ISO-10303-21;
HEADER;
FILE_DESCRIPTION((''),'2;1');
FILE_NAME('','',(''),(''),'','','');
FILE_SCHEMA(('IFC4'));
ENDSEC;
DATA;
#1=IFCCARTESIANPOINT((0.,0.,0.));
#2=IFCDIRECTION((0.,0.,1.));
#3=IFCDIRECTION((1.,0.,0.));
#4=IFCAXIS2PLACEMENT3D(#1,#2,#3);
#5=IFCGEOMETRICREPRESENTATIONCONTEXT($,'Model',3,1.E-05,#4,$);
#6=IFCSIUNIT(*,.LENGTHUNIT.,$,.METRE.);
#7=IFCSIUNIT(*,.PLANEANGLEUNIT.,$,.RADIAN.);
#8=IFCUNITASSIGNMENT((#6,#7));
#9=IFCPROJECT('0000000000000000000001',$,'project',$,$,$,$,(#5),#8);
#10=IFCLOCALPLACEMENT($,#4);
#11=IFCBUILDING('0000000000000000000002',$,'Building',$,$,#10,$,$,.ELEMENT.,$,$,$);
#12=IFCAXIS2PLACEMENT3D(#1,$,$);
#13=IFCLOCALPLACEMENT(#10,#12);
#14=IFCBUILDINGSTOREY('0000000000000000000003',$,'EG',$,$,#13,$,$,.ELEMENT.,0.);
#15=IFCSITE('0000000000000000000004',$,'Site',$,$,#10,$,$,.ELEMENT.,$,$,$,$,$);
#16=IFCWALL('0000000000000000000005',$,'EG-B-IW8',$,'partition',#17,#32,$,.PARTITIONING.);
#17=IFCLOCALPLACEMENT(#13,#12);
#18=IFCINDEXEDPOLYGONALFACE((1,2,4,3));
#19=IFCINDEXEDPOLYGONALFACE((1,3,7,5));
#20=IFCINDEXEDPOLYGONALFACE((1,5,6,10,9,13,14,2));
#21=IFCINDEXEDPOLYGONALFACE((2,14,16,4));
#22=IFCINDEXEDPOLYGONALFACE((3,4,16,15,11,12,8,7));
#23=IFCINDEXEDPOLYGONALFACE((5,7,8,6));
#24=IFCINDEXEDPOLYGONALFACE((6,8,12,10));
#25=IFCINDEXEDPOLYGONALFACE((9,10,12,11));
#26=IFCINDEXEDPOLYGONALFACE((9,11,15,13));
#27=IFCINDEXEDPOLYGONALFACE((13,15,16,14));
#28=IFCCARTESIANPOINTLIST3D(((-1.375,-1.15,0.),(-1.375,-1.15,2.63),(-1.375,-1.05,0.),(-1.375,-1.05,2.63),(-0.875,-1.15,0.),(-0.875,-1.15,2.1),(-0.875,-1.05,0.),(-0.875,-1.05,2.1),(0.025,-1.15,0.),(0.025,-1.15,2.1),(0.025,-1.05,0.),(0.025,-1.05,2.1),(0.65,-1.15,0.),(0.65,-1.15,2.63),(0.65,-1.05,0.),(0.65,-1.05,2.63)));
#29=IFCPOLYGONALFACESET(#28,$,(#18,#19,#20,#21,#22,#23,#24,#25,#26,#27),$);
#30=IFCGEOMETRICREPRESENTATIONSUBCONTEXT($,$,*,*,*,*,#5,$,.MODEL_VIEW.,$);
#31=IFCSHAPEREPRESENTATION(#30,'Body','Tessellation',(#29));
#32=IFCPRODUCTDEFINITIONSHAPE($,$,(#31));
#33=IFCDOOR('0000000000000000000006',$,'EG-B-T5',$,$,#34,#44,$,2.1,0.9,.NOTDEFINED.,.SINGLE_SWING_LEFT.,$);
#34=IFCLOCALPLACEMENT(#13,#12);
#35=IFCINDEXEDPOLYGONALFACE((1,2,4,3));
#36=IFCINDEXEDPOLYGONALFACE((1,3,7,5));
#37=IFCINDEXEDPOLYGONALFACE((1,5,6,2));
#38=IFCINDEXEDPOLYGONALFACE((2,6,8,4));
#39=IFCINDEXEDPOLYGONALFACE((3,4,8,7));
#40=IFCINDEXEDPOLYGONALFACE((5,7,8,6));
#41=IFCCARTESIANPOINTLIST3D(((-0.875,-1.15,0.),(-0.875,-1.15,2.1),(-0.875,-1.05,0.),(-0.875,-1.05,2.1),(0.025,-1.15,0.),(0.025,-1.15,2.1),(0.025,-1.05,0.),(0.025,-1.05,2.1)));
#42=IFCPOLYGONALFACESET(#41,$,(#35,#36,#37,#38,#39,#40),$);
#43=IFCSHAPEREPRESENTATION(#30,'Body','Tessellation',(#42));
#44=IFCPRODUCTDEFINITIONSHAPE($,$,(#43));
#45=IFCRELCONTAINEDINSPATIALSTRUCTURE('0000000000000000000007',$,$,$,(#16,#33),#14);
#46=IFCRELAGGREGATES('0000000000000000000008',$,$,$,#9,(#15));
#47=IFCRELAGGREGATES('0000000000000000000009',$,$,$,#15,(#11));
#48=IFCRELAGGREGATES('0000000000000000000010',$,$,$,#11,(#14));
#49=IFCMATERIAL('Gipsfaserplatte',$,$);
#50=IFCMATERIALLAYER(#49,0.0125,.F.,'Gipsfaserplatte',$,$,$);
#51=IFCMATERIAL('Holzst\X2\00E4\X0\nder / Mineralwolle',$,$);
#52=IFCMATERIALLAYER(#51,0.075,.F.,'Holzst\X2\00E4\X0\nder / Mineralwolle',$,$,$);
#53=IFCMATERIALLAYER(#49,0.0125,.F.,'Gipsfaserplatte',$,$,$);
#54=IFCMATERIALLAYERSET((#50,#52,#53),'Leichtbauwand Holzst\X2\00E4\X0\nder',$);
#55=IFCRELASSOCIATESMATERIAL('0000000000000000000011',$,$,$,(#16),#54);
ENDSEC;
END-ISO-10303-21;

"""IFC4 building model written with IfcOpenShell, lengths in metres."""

from ifc_helpers import new_model, si_unit, frame, frame_2d, origin, origin_with_axes, place, context, subcontext, project, spatial, rectangle, extrude, material, layer, layer_set, element, fill, save


model = new_model("IFC4")

# Units and contexts
model_context = context("Model", 3, precision=1e-05, world=origin_with_axes())
sub_context = subcontext(model_context, None, None, "MODEL_VIEW")
ifc_project = project(units=[si_unit("LENGTHUNIT", "METRE"), si_unit("PLANEANGLEUNIT", "RADIAN")], contexts=[model_context])

# Site, building, storey
placement = place(None, origin_with_axes())
site = spatial("IfcSite", under=ifc_project, at=placement, Name="Site", CompositionType="ELEMENT")
building = spatial("IfcBuilding", under=site, at=placement, Name="Building", CompositionType="ELEMENT")
storey_placement = place(placement, origin())
storey = spatial("IfcBuildingStorey", under=building, at=storey_placement, Name="EG", CompositionType="ELEMENT", Elevation=0.0)

# Shared definitions
ifc_material_1 = material(Name="Gipsfaserplatte")

# Shared definitions
ifc_material_2 = material(Name="Holzständer / Mineralwolle")

# Wall, opening, door
ifc_layer_1 = layer(ifc_material_1, 0.0125, ventilated=False, Name="Gipsfaserplatte")
ifc_layer_2 = layer(ifc_material_2, 0.075, ventilated=False, Name="Holzständer / Mineralwolle")
ifc_layer_3 = layer(ifc_material_1, 0.0125, ventilated=False, Name="Gipsfaserplatte")
ifc_layer_set_1 = layer_set([ifc_layer_1, ifc_layer_2, ifc_layer_3], Name="Leichtbauwand Holzständer")
wall_1_placement = place(storey_placement, frame((-1.375, -1.1, 0.0), z_axis=(0.0, 0.0, 1.0), x_axis=(1.0, 0.0, 0.0)))
wall_1 = element("IfcWall", 1, at=wall_1_placement, inside=storey, material=ifc_layer_set_1, Name="EG-B-IW8", ObjectType="partition", PredefinedType="PARTITIONING", context=sub_context, shape_type="SweptSolid", body=[
    extrude(rectangle(XDim=2.025, YDim=0.1, at=frame_2d((1.0125, 0.0))), origin(), (0.0, 0.0, 1.0), 2.63),
])
opening_1_placement = place(wall_1_placement, frame((0.95, 0.1, 0.0), z_axis=(0.0, -1.0, 0.0), x_axis=(1.0, 0.0, 0.0)))
opening_1 = element("IfcOpeningElement", 2, at=opening_1_placement, cuts=wall_1, PredefinedType="OPENING", context=sub_context, shape_type="SweptSolid", body=[
    extrude(rectangle(XDim=0.9, YDim=2.1, at=frame_2d((0.0, 1.05))), origin(), (0.0, 0.0, 1.0), 0.2),
])
door_1_placement = place(wall_1_placement, frame((0.95, 0.05, 0.0), z_axis=(0.0, -1.0, 0.0), x_axis=(1.0, 0.0, 0.0)))
door_1 = element("IfcDoor", 3, at=door_1_placement, inside=storey, Name="EG-B-T5", OperationType="SINGLE_SWING_LEFT", OverallHeight=2.1, OverallWidth=0.9, PredefinedType="NOTDEFINED", context=sub_context, shape_type="SweptSolid", body=[
    extrude(rectangle(XDim=0.9, YDim=2.1, at=frame_2d((0.0, 1.05))), origin(), (0.0, 0.0, 1.0), 0.1),
])
fill(opening_1, door_1)

save(model, "model.ifc")
